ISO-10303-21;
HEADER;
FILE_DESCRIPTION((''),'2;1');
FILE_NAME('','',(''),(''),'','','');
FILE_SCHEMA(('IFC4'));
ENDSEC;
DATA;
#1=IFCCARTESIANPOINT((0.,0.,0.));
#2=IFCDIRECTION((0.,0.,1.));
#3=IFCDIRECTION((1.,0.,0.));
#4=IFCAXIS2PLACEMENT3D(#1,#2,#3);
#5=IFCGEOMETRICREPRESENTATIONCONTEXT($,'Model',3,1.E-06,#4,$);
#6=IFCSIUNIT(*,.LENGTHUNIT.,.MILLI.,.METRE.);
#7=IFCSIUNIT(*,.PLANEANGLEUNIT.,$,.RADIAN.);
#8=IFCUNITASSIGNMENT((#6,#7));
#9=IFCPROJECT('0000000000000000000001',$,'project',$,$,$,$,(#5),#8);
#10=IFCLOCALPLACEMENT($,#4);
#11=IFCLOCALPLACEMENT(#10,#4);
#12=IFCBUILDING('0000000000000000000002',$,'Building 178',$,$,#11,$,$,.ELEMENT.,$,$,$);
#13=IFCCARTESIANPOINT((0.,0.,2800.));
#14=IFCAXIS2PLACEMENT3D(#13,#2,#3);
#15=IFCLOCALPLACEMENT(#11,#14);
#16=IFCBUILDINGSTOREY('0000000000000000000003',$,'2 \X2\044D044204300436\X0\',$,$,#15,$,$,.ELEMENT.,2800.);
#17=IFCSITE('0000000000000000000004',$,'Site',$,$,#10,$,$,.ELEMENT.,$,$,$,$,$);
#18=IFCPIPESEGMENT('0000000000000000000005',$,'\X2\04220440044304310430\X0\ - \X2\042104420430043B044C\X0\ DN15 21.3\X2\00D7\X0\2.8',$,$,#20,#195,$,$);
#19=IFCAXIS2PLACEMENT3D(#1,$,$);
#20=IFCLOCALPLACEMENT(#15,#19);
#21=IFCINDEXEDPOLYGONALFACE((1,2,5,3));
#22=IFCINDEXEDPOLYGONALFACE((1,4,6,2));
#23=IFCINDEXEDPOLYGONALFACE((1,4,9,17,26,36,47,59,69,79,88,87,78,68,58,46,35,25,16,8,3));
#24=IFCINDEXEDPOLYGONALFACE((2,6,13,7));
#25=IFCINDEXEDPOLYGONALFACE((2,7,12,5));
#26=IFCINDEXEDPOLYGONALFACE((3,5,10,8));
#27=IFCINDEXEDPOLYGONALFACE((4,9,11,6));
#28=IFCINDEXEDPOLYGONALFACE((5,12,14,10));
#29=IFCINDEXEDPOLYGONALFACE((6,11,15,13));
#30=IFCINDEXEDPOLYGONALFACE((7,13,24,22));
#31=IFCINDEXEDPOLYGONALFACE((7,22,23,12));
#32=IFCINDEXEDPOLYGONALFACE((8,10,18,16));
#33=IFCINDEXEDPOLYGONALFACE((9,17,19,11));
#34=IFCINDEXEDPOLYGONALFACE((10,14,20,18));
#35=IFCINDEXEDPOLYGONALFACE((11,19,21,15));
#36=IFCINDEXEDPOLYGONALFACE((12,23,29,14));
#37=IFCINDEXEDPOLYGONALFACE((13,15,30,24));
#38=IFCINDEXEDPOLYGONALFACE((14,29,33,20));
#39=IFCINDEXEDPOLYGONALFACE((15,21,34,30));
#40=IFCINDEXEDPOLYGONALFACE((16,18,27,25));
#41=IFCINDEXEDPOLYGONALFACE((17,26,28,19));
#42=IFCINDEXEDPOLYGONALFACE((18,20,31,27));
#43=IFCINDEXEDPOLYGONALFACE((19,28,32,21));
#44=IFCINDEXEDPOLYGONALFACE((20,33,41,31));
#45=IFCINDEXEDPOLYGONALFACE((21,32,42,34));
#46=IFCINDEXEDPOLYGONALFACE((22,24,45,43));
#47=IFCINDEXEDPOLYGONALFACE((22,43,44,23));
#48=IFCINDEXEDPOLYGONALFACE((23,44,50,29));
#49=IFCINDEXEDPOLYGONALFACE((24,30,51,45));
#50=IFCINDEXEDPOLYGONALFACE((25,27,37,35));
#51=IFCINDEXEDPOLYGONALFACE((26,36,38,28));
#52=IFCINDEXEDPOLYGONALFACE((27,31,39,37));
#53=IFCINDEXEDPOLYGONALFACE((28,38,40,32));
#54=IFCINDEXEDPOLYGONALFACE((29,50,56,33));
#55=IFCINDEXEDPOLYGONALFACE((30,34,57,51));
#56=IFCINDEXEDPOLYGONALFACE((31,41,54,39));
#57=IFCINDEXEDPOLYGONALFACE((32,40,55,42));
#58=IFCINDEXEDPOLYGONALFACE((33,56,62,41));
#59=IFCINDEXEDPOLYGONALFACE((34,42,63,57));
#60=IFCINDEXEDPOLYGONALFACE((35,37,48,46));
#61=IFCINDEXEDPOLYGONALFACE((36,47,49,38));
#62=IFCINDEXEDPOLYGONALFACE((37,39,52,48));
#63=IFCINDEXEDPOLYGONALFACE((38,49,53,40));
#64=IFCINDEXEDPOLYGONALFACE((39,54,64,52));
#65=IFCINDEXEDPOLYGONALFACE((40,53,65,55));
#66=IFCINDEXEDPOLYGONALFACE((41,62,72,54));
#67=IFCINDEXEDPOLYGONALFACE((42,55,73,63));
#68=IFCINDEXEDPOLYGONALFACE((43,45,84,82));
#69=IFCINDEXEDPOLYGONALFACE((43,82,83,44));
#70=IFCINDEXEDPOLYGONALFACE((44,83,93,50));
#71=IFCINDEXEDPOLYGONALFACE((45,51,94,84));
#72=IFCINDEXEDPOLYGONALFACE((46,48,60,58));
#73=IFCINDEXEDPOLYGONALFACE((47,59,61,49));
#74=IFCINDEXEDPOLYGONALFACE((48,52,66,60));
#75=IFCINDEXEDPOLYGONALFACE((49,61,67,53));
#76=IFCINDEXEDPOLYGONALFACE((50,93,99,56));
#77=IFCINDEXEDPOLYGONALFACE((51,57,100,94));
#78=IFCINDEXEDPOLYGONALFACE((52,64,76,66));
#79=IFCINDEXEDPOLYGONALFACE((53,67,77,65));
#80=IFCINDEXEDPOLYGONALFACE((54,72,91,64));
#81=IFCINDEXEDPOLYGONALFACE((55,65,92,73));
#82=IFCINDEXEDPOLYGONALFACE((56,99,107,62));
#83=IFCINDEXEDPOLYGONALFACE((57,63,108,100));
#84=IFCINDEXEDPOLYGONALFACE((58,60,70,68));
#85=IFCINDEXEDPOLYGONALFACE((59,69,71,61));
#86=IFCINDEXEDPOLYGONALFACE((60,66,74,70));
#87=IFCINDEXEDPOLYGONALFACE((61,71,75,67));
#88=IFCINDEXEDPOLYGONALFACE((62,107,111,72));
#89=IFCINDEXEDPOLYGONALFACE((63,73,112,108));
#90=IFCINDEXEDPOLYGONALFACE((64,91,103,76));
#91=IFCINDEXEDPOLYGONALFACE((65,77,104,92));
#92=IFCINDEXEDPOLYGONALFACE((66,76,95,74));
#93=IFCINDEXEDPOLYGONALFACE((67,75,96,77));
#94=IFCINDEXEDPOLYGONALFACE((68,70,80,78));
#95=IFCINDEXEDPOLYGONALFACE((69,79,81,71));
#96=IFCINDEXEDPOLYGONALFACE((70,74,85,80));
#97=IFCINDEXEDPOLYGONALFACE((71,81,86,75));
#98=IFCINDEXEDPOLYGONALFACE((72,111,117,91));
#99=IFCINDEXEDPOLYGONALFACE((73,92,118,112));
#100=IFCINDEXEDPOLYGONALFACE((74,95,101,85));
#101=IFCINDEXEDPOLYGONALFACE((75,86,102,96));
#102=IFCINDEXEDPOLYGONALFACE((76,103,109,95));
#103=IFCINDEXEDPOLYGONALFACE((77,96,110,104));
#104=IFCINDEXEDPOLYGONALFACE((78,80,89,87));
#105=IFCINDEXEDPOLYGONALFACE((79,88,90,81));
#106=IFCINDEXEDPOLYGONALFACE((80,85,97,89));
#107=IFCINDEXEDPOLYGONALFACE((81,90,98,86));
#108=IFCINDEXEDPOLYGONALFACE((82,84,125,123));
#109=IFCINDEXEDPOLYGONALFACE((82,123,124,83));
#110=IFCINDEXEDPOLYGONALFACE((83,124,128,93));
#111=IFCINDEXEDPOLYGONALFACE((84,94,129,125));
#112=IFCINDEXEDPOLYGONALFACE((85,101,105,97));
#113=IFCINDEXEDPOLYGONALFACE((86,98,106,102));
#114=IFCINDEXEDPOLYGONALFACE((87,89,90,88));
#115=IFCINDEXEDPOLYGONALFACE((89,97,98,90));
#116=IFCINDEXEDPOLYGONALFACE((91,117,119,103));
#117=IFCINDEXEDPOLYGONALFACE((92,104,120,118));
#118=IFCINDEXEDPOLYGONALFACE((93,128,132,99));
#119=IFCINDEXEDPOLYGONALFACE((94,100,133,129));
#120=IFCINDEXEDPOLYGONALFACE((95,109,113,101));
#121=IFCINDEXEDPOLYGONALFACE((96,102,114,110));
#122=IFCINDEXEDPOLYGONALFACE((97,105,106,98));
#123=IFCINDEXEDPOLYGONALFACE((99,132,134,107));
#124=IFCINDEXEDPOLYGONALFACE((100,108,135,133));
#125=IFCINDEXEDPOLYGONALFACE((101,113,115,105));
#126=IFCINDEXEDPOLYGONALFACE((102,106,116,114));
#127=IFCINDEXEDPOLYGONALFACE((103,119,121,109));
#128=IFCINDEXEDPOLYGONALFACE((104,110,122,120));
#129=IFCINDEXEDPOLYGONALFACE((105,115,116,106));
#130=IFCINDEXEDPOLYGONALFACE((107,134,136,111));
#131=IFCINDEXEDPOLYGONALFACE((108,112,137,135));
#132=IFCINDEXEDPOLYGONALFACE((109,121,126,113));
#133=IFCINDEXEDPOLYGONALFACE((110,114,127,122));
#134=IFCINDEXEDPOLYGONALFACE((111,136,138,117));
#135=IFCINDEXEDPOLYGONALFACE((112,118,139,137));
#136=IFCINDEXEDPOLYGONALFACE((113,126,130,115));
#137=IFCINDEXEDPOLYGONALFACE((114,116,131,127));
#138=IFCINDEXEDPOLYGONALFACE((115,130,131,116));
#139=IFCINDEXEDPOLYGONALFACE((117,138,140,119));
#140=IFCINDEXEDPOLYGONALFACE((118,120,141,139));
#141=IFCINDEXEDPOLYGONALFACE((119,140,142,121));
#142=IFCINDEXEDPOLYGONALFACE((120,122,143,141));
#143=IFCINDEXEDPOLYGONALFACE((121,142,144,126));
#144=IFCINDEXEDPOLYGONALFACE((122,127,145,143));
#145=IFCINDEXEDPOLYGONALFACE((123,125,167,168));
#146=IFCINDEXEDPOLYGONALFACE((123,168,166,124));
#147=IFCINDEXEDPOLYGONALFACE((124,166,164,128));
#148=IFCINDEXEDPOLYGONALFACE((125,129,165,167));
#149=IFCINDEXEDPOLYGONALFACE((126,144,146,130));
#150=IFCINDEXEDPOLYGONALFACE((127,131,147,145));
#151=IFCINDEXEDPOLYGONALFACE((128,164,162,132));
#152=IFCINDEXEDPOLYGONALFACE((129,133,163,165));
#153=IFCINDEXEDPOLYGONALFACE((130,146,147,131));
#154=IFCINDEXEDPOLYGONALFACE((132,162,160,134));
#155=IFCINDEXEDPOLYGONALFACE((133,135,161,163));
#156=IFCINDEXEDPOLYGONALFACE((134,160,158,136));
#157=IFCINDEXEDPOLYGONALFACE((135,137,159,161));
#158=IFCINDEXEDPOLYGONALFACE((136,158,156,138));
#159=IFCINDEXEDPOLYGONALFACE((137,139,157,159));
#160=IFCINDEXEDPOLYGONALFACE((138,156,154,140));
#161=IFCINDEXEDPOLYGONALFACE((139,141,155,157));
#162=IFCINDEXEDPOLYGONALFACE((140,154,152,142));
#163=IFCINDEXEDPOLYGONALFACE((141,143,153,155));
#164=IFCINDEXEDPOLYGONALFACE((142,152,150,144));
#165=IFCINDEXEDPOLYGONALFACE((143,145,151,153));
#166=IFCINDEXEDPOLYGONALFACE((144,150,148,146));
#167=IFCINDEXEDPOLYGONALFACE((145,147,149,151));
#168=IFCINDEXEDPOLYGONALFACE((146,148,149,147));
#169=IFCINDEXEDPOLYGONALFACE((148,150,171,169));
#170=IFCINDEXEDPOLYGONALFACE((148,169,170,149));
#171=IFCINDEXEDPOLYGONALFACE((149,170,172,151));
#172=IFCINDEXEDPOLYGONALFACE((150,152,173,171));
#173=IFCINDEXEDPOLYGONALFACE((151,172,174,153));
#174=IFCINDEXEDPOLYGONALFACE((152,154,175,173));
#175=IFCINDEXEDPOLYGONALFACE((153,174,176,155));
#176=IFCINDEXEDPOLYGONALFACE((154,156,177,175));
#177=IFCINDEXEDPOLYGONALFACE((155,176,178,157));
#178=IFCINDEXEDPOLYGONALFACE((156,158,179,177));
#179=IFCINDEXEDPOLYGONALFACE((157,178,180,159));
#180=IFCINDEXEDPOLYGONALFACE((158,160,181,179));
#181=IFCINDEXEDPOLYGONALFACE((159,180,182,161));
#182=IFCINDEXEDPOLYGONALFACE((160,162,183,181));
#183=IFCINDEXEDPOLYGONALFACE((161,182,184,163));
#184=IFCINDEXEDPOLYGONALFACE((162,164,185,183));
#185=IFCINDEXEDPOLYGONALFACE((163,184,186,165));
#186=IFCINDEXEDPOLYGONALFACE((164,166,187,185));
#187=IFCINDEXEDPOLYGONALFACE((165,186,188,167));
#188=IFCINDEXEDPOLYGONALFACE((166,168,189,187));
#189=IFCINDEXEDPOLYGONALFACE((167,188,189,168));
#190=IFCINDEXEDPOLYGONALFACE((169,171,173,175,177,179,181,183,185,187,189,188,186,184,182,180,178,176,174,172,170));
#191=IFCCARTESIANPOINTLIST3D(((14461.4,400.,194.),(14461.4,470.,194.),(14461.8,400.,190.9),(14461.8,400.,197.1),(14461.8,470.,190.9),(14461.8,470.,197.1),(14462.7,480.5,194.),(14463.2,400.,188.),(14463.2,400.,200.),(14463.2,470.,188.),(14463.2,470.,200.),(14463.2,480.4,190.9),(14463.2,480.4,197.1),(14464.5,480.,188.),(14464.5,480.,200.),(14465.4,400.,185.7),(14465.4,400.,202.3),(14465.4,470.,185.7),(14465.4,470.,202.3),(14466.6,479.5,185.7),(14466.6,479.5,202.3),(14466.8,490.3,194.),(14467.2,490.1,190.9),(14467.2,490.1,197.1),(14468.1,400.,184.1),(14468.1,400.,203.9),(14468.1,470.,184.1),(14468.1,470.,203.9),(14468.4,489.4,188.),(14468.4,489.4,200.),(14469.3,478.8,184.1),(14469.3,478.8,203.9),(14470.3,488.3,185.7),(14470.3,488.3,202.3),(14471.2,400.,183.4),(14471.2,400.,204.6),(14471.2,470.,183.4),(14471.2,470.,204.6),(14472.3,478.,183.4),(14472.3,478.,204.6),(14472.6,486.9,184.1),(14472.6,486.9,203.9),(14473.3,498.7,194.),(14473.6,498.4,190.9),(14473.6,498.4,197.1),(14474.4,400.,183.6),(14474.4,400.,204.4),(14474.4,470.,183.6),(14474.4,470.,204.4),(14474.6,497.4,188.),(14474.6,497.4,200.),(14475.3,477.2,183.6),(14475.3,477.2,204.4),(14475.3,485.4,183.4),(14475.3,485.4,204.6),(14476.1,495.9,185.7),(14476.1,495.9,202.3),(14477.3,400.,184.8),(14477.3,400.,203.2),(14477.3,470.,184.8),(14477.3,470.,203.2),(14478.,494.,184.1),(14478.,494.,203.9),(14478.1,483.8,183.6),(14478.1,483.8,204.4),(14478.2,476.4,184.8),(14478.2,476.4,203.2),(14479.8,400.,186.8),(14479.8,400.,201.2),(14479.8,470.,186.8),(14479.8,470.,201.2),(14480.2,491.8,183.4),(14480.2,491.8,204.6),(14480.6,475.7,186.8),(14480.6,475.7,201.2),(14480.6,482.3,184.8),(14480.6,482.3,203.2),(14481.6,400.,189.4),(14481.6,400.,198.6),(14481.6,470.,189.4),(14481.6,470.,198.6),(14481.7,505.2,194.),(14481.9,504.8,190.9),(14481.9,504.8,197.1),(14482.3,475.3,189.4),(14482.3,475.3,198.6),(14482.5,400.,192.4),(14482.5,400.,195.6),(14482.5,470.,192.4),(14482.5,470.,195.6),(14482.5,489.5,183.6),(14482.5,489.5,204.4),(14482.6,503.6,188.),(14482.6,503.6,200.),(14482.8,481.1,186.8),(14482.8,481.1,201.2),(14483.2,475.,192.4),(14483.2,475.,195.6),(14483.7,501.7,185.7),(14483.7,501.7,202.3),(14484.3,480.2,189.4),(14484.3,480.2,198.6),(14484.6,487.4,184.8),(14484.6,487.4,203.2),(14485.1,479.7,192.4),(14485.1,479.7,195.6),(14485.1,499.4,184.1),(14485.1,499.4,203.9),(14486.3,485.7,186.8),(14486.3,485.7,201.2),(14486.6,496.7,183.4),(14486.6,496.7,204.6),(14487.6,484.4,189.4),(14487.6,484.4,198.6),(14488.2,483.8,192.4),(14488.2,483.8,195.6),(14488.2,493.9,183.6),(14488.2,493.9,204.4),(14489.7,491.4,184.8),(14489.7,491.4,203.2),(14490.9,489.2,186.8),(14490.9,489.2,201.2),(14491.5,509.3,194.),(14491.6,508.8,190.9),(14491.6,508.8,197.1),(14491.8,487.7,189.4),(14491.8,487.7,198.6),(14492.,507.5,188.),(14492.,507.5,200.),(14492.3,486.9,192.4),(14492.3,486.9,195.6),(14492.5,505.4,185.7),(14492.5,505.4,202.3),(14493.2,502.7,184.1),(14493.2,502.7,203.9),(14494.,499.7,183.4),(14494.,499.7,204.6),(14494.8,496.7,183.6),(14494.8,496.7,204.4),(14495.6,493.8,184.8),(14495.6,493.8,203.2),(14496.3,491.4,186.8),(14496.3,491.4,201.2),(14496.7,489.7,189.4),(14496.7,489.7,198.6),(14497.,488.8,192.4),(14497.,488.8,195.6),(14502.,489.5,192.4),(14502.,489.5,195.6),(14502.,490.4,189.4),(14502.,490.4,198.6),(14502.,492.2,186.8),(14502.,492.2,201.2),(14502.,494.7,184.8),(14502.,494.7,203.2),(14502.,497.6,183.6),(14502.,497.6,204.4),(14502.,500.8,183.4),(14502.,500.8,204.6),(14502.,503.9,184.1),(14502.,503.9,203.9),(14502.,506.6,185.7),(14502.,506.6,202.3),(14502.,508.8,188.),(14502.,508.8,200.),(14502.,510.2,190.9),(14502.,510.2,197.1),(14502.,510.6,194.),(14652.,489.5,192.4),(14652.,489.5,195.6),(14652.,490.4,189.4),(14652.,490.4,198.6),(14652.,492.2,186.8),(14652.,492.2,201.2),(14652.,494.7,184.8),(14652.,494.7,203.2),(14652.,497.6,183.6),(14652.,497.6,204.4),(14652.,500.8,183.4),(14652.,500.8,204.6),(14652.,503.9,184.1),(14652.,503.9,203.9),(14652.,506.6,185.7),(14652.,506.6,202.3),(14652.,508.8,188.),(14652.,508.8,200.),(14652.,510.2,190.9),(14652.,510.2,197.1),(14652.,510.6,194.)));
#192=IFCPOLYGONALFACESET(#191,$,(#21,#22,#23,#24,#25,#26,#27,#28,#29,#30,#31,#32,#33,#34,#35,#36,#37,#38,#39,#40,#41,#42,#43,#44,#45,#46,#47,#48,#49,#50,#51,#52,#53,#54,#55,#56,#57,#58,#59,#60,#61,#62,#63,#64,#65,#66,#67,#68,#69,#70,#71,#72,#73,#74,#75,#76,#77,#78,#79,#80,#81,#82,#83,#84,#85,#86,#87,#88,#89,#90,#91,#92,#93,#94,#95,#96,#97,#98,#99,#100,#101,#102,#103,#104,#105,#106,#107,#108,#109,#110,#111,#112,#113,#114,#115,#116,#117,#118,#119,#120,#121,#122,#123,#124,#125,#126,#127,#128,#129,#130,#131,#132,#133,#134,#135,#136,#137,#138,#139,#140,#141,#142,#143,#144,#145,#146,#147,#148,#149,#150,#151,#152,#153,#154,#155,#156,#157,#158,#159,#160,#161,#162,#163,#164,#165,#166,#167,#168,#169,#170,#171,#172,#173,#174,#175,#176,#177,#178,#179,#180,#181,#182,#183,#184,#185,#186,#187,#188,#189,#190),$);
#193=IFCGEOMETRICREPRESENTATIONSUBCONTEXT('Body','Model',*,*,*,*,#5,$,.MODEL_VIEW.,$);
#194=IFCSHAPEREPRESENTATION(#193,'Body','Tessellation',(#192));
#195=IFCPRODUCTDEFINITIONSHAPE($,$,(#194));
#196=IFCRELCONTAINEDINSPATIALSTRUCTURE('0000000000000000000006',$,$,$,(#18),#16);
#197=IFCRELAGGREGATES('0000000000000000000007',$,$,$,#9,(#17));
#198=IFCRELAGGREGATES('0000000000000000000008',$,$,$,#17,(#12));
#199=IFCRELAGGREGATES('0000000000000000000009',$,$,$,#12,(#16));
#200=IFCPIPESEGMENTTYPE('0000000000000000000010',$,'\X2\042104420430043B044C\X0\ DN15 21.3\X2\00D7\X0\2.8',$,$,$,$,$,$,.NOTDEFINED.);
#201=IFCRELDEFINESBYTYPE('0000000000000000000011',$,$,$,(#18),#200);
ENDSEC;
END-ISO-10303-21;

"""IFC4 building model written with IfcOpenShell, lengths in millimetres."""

from ifc_helpers import new_model, entity, si_unit, frame, origin_with_axes, place, context, subcontext, project, spatial, source, transform, mapped, type_object, element, save


model = new_model("IFC4")

# Units and contexts
model_context = context("Model", 3, precision=1e-06, world=origin_with_axes())
body_context = subcontext(model_context, "Body", "Model", "MODEL_VIEW")
ifc_project = project(units=[si_unit("LENGTHUNIT", "METRE", prefix="MILLI"), si_unit("PLANEANGLEUNIT", "RADIAN")], contexts=[model_context])

# Site, building, storey
site_placement = place(None, origin_with_axes())
site = spatial("IfcSite", under=ifc_project, at=site_placement, Name="Site", CompositionType="ELEMENT")
building_placement = place(site_placement, origin_with_axes())
building = spatial("IfcBuilding", under=site, at=building_placement, Name="Building 178", CompositionType="ELEMENT")
storey_placement = place(building_placement, frame((0.0, 0.0, 2800.0), z_axis=(0.0, 0.0, 1.0), x_axis=(1.0, 0.0, 0.0)))
storey = spatial("IfcBuildingStorey", under=building, at=storey_placement, Name="2 этаж", CompositionType="ELEMENT", Elevation=2800.0)

# Pipe segment
pipe_segment_type = type_object("IfcPipeSegmentType", Name="Сталь DN15 21.3×2.8", PredefinedType="NOTDEFINED")
shared_shape_1 = source(origin_with_axes(), body_context, "Body", "AdvancedSweptSolid", [
    entity("IfcSweptDiskSolid", entity("IfcIndexedPolyCurve", entity("IfcCartesianPointList3D", [[0.0, 0.0, 0.0], [0.0, 0.0, -70.0], [8.8, 0.0, -91.2], [30.0, 0.0, -100.0], [180.0, 0.0, -100.0]]), [entity("IfcLineIndex", [1, 2]), entity("IfcArcIndex", [2, 3, 4]), entity("IfcLineIndex", [4, 5])]), 10.7),
])
for number, where, z_axis, x_axis, name in (
    (1, (14472.0, 400.0, 194.0), (0.0, -1.0, 0.0), (1.0, 0.0, 0.0), "Труба - Сталь DN15 21.3×2.8"),
):
    element("IfcPipeSegment", number, at=place(storey_placement, frame(where, z_axis=z_axis, x_axis=x_axis)), inside=storey, type_object=pipe_segment_type, Name=name, context=body_context, shape_type="MappedRepresentation", body=[
        mapped(shared_shape_1, transform((0.0, 0.0, 0.0), x_axis=(1.0, 0.0, 0.0), y_axis=(0.0, 1.0, 0.0), z_axis=(0.0, 0.0, 1.0), scale=1.0)),
    ])

save(model, "model.ifc")
